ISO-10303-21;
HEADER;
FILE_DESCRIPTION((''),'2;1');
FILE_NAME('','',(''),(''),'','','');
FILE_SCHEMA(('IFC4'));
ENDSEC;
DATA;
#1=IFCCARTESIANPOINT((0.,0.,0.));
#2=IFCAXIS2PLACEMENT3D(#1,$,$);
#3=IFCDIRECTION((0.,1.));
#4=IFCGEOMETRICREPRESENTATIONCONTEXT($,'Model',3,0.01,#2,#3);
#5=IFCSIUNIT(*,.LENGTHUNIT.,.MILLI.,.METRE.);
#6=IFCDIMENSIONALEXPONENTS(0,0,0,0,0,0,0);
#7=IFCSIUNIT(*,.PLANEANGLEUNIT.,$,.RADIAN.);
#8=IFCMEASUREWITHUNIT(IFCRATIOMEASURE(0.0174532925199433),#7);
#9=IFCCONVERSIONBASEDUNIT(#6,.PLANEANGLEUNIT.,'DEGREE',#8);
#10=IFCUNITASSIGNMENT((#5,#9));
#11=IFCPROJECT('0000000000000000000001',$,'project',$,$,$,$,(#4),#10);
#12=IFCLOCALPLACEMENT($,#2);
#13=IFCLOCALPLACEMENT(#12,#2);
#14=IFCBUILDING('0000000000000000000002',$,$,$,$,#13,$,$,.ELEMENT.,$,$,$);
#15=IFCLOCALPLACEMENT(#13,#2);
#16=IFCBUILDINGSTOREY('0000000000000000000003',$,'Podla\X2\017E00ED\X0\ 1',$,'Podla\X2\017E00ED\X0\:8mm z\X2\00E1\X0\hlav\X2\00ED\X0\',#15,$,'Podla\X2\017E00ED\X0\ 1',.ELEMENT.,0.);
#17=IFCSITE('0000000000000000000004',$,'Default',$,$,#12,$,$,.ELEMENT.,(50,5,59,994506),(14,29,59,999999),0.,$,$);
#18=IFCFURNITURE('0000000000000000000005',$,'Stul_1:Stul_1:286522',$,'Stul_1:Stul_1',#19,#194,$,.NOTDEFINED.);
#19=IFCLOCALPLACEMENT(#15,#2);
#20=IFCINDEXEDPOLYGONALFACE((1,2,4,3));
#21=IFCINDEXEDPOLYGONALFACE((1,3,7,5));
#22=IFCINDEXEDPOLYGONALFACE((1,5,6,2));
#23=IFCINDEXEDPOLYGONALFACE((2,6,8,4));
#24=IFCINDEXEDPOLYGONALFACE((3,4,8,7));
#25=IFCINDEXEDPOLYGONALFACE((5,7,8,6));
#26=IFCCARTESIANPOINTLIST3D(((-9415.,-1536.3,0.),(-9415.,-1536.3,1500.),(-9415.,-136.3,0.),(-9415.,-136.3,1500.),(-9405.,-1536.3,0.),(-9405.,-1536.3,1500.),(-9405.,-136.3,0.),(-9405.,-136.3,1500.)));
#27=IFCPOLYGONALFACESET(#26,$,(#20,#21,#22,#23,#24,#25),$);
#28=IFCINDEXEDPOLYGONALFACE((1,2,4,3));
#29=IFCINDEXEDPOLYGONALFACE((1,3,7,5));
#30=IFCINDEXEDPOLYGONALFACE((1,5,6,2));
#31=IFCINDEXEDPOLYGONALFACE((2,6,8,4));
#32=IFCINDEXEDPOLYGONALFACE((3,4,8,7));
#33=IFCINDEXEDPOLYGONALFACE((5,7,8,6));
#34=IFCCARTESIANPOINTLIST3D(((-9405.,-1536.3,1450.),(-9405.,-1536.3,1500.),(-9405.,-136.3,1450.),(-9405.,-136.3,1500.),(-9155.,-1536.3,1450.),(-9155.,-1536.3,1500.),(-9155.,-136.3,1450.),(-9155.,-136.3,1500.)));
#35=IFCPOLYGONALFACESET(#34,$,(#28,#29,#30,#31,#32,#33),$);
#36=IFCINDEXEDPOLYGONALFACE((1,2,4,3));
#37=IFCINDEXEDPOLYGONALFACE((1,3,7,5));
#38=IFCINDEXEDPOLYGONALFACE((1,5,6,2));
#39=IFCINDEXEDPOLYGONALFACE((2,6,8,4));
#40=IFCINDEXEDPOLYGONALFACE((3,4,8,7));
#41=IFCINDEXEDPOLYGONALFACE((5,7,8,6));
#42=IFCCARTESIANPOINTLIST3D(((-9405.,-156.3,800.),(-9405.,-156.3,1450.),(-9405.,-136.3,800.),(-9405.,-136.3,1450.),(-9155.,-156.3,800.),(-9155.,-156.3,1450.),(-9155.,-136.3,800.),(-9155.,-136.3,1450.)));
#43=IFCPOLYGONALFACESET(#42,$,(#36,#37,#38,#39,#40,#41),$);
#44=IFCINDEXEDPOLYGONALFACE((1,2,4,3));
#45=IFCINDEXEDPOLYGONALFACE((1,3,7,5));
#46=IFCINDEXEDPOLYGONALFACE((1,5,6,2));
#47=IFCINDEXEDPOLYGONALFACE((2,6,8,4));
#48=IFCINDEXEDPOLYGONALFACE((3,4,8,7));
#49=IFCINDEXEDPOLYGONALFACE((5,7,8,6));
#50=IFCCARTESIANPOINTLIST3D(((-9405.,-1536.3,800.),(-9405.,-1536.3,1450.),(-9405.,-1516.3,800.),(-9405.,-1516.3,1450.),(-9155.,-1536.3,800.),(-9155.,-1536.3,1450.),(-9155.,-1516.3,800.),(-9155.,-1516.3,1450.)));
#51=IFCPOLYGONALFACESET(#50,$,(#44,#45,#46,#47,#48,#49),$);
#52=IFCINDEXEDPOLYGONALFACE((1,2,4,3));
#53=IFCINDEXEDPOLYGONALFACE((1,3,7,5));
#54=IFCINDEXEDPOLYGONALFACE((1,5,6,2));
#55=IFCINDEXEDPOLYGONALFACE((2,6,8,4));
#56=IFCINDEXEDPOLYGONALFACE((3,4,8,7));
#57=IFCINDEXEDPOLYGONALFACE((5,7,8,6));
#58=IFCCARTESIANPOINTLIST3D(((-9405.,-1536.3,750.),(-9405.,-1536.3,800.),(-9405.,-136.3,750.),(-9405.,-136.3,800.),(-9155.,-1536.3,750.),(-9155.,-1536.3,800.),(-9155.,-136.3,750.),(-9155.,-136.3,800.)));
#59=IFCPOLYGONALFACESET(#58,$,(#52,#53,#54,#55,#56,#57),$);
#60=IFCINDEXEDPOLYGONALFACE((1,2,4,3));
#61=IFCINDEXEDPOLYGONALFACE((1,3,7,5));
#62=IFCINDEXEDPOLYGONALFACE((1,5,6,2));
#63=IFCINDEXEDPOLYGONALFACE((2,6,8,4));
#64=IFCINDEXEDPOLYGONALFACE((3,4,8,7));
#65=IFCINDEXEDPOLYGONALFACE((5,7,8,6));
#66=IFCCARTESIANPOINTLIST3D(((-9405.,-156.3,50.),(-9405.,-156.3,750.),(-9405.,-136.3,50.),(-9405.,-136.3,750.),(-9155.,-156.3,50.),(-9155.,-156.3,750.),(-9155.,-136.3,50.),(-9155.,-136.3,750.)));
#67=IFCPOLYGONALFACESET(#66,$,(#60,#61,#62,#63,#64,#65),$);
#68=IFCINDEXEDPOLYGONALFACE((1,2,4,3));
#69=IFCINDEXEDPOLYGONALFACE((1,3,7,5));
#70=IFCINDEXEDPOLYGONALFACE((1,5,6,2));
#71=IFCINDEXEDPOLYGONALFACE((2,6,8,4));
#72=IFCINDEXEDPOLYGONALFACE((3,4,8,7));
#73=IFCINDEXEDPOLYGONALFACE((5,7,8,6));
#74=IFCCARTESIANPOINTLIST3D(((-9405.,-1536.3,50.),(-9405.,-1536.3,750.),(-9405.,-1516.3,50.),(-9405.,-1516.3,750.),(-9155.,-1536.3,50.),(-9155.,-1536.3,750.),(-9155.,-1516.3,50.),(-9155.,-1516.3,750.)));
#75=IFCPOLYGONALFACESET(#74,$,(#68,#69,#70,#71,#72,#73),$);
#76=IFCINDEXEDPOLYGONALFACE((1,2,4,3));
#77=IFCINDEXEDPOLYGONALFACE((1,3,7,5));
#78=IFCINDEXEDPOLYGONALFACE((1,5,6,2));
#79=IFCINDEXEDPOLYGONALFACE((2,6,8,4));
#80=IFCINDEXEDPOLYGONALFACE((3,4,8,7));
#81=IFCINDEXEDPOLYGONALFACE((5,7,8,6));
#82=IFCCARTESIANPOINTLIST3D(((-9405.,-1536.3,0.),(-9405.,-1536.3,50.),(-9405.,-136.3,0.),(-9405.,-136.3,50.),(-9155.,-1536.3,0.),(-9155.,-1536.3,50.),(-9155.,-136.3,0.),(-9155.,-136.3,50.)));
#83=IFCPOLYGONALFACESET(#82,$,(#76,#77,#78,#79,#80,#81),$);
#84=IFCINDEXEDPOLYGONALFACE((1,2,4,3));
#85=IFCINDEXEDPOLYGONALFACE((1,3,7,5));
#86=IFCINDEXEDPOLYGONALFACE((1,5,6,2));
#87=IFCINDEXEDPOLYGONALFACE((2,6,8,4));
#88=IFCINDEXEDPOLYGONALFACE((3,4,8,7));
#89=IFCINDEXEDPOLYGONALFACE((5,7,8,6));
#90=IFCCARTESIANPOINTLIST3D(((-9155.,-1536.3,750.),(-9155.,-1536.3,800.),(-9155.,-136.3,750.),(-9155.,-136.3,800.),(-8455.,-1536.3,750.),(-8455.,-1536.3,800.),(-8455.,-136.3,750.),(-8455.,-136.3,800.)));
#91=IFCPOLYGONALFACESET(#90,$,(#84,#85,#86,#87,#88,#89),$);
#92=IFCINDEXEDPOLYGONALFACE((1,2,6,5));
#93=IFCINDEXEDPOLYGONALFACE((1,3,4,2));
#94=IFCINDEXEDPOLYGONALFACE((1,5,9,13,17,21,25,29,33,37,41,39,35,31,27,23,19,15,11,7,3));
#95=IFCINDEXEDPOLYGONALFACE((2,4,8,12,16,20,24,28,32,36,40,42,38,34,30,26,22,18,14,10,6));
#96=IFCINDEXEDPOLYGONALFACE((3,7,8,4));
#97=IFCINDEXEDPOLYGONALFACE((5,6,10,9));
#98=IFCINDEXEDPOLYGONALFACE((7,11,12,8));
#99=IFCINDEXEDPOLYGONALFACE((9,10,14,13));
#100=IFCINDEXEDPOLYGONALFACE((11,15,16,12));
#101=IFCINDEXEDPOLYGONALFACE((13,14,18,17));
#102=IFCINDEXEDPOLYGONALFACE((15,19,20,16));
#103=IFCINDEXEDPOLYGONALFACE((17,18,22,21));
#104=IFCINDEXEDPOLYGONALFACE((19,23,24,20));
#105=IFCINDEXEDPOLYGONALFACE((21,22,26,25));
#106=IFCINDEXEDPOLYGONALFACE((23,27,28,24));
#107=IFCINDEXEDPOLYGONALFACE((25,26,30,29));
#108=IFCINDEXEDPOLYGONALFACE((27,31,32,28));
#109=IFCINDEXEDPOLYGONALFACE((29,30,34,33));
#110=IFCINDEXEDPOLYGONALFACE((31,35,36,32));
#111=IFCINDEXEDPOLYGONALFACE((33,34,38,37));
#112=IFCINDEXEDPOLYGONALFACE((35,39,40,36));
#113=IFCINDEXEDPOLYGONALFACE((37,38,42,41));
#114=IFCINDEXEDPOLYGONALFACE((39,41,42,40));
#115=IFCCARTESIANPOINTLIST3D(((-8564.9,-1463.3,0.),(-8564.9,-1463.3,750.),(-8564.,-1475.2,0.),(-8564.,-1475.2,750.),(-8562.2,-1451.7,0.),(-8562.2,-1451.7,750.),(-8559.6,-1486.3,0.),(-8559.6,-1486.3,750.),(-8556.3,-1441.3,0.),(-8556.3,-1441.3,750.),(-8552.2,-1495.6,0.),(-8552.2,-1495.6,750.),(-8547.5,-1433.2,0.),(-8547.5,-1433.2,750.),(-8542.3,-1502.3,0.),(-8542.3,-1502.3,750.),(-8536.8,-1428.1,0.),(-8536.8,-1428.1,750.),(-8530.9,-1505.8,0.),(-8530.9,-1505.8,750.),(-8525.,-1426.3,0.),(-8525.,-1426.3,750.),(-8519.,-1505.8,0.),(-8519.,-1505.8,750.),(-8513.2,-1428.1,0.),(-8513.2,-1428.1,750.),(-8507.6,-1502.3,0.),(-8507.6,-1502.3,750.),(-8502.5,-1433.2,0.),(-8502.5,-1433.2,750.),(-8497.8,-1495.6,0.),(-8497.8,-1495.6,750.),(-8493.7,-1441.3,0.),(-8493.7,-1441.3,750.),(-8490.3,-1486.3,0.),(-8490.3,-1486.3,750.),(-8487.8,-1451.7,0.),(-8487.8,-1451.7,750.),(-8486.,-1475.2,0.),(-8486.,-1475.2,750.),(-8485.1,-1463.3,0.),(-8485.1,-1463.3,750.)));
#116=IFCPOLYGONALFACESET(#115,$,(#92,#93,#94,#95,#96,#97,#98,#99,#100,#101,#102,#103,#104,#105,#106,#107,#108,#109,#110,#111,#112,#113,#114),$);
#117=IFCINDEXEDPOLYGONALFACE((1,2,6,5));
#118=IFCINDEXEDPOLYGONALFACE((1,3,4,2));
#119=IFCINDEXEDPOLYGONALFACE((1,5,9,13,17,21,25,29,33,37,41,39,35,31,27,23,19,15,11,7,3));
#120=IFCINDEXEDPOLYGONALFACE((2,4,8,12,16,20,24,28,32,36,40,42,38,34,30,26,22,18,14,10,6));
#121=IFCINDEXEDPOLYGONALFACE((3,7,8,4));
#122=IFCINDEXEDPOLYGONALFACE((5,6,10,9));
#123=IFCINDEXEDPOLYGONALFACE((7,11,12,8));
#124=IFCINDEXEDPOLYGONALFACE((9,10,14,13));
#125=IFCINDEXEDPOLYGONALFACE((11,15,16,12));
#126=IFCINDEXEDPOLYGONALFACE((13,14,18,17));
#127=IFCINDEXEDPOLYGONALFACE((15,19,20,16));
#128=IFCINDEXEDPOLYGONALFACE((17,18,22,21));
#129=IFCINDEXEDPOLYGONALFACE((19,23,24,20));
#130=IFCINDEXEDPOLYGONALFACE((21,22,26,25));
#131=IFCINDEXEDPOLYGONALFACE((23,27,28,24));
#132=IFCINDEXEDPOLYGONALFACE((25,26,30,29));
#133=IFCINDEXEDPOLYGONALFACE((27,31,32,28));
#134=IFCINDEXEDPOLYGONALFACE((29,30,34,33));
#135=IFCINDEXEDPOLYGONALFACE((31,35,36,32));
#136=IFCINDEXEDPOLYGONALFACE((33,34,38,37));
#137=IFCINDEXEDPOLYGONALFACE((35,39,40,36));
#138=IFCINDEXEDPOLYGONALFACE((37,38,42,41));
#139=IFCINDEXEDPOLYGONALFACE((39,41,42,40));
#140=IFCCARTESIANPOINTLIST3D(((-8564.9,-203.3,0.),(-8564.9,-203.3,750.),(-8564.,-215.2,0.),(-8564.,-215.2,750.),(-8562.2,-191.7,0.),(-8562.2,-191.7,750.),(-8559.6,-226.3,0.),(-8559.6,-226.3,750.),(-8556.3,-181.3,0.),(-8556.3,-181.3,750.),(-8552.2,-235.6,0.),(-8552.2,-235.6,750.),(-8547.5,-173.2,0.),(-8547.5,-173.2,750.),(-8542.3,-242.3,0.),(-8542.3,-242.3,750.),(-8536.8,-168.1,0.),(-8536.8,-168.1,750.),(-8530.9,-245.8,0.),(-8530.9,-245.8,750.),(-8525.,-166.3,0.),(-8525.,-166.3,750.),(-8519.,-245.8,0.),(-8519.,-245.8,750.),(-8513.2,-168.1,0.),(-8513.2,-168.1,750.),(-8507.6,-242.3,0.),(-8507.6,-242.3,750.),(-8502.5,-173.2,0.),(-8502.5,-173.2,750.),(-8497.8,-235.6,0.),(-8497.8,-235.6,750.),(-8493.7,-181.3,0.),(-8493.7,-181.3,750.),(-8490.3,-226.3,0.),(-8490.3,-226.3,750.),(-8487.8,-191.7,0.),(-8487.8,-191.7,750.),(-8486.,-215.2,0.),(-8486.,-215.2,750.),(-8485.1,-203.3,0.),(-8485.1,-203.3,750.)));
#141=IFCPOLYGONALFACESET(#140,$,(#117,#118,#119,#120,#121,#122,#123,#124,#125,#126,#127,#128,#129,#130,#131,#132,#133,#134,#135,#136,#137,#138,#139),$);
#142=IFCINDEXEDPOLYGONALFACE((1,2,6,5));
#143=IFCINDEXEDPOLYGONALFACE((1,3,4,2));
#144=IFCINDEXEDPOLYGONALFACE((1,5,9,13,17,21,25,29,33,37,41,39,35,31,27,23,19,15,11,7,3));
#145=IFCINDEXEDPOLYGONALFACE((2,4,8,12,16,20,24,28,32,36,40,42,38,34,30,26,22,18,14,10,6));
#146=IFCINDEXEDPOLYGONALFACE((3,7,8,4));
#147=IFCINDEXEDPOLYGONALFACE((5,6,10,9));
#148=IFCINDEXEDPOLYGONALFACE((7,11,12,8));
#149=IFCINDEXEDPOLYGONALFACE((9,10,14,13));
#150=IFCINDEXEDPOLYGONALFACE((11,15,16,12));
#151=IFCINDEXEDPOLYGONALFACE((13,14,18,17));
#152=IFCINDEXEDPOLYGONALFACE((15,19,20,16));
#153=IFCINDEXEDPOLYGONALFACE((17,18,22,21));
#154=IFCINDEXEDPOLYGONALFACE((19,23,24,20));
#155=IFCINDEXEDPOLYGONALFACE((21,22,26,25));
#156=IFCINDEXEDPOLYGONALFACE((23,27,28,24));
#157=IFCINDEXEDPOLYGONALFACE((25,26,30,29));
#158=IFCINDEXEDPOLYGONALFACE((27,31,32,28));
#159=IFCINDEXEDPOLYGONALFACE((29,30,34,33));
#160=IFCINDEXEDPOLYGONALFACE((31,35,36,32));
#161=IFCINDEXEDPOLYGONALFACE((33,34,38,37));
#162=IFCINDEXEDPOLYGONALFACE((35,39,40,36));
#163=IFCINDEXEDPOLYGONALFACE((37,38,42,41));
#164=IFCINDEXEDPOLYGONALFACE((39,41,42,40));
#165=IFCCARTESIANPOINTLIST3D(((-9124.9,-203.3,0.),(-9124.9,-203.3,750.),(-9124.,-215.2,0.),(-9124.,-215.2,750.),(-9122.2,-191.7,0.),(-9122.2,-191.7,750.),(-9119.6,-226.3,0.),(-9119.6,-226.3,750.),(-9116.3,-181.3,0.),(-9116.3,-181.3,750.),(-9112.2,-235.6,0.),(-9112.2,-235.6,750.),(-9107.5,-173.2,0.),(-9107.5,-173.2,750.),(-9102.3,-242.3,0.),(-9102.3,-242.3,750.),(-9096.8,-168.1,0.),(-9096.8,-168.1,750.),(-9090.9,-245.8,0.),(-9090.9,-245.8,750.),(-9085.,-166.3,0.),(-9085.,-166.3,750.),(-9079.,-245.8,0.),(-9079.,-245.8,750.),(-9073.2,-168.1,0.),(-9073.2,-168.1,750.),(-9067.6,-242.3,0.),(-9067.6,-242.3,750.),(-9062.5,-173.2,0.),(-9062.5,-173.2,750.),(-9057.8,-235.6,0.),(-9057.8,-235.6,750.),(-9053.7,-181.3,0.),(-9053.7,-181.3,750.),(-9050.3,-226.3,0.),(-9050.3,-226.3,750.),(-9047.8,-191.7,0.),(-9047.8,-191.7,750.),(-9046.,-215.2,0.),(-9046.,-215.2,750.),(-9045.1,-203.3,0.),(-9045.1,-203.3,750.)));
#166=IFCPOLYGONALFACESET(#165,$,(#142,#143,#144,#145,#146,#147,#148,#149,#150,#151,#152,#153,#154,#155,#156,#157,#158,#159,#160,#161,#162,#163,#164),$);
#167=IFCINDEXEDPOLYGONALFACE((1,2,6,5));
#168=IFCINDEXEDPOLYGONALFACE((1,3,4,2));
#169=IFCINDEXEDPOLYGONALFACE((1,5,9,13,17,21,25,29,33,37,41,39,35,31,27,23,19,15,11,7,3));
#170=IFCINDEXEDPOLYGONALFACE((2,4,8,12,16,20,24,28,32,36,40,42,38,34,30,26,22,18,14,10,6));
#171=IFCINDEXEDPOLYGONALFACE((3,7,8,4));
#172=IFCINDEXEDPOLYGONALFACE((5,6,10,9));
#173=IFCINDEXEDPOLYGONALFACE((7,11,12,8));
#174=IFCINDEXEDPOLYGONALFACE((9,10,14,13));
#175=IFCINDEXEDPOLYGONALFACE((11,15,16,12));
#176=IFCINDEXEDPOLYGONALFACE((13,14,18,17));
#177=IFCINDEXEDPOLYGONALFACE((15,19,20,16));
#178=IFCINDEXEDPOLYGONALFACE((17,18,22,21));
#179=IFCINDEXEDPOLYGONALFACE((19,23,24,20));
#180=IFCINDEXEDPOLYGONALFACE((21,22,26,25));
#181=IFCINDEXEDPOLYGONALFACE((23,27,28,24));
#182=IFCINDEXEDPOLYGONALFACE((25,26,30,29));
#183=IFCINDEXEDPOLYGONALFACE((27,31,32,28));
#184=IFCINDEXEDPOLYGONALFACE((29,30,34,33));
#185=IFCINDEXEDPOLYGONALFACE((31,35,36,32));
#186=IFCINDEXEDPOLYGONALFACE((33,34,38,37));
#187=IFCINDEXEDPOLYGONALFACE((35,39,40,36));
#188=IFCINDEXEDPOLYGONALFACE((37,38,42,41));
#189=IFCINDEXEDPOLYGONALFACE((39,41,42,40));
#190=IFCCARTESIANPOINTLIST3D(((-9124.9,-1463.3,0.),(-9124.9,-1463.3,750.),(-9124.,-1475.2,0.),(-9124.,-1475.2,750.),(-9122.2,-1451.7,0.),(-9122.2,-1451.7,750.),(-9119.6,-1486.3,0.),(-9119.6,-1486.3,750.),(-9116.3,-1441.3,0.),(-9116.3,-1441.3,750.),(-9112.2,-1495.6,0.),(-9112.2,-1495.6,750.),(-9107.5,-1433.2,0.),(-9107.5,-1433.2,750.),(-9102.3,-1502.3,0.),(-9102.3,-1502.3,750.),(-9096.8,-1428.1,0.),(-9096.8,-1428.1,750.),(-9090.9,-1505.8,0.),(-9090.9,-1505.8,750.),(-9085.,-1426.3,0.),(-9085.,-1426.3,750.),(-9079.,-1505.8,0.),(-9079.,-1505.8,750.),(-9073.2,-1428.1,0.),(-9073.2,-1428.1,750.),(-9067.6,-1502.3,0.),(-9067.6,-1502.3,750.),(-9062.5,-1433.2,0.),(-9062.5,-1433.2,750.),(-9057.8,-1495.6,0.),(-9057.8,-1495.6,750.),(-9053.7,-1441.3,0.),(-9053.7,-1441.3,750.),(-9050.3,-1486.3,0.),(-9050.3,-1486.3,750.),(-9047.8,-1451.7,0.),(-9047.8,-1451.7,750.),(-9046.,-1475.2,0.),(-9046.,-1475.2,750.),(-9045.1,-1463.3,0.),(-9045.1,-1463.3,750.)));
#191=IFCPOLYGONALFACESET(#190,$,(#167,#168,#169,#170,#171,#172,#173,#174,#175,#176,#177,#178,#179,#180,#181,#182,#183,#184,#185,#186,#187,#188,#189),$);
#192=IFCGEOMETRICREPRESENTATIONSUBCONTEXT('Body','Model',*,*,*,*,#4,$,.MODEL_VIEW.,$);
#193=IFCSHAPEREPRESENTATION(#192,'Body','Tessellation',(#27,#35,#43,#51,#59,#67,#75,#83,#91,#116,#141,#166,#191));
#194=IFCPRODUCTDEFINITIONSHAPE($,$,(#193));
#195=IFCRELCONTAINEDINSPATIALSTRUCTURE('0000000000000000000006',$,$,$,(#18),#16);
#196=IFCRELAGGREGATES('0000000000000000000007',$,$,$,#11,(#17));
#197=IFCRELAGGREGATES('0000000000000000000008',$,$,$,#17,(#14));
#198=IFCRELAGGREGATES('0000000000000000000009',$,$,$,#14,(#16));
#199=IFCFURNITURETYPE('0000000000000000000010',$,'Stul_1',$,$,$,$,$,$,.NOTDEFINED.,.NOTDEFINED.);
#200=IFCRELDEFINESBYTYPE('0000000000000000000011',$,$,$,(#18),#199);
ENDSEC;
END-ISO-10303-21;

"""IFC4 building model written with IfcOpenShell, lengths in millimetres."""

from ifc_helpers import new_model, entity, si_unit, converted_unit, direction, frame, frame_2d, origin, origin_2d_with_axis, place, context, subcontext, project, spatial, rectangle, circle, extrude, source, transform, mapped, type_object, type_shapes, element, save


model = new_model("IFC4")

# Units and contexts
model_context = context("Model", 3, precision=0.01, world=origin(), true_north=direction((0.0, 1.0)))
body_context = subcontext(model_context, "Body", "Model", "MODEL_VIEW")
ifc_project = project(units=[si_unit("LENGTHUNIT", "METRE", prefix="MILLI"), converted_unit("PLANEANGLEUNIT", "DEGREE", entity("IfcRatioMeasure", 0.0174532925199433), si_unit("PLANEANGLEUNIT", "RADIAN"), dimensions=[0, 0, 0, 0, 0, 0, 0])], contexts=[model_context])

# Site, building, storey
site_placement = place(None, origin())
site = spatial("IfcSite", under=ifc_project, at=site_placement, Name="Default", CompositionType="ELEMENT", RefLatitude=(50, 5, 59, 994506), RefLongitude=(14, 29, 59, 999999), RefElevation=0.0)
building_placement = place(site_placement, origin())
building = spatial("IfcBuilding", under=site, at=building_placement, CompositionType="ELEMENT")
storey_placement = place(building_placement, origin())
storey = spatial("IfcBuildingStorey", under=building, at=storey_placement, Name="Podlaží 1", ObjectType="Podlaží:8mm záhlaví", LongName="Podlaží 1", CompositionType="ELEMENT", Elevation=0.0)

# Furniture
furniture_type = type_object("IfcFurnitureType", Name="Stul_1", AssemblyPlace="NOTDEFINED", PredefinedType="NOTDEFINED")
shared_shape_1 = source(origin(), body_context, "Body", "SweptSolid", [
    extrude(rectangle(XDim=1400.0, YDim=10.0, at=origin_2d_with_axis()), frame((0.0, 605.0, 0.0), z_axis=(0.0, 0.0, 1.0), x_axis=(-1.0, 0.0, 0.0)), (0.0, 0.0, 1.0), 1500.0),
    extrude(rectangle(XDim=1400.0, YDim=250.0, at=frame_2d((0.0, 0.0), x_axis=(1.0, 0.0))), frame((0.0, 475.0, 1450.0), z_axis=(0.0, 0.0, 1.0), x_axis=(-1.0, 0.0, 0.0)), (0.0, 0.0, 1.0), 50.0),
    extrude(rectangle(XDim=20.0, YDim=250.0, at=origin_2d_with_axis()), frame((690.0, 475.0, 800.0), z_axis=(0.0, 0.0, 1.0), x_axis=(-1.0, 0.0, 0.0)), (0.0, 0.0, 1.0), 650.0),
    extrude(rectangle(XDim=20.0, YDim=250.0, at=frame_2d((0.0, 0.0), x_axis=(1.0, 0.0))), frame((-690.0, 475.0, 800.0), z_axis=(0.0, 0.0, 1.0), x_axis=(-1.0, 0.0, 0.0)), (0.0, 0.0, 1.0), 650.0),
    extrude(rectangle(XDim=1400.0, YDim=250.0, at=origin_2d_with_axis()), frame((0.0, 475.0, 750.0), z_axis=(0.0, 0.0, 1.0), x_axis=(-1.0, 0.0, 0.0)), (0.0, 0.0, 1.0), 50.0),
    extrude(rectangle(XDim=20.0, YDim=250.0, at=origin_2d_with_axis()), frame((690.0, 475.0, 50.0), z_axis=(0.0, 0.0, 1.0), x_axis=(-1.0, 0.0, 0.0)), (0.0, 0.0, 1.0), 700.0),
    extrude(rectangle(XDim=20.0, YDim=250.0, at=frame_2d((0.0, 0.0), x_axis=(1.0, 0.0))), frame((-690.0, 475.0, 50.0), z_axis=(0.0, 0.0, 1.0), x_axis=(-1.0, 0.0, 0.0)), (0.0, 0.0, 1.0), 700.0),
    extrude(rectangle(XDim=1400.0, YDim=250.0, at=origin_2d_with_axis()), frame((0.0, 475.0, 0.0), z_axis=(0.0, 0.0, 1.0), x_axis=(-1.0, 0.0, 0.0)), (0.0, 0.0, 1.0), 50.0),
    extrude(rectangle(XDim=1400.0, YDim=700.0, at=origin_2d_with_axis()), frame((0.0, 0.0, 750.0), z_axis=(0.0, 0.0, 1.0), x_axis=(-1.0, 0.0, 0.0)), (0.0, 0.0, 1.0), 50.0),
    extrude(circle(Radius=40.0, at=frame_2d((0.0, 0.0), x_axis=(1.0, 0.0))), frame((-630.0, -280.0, 0.0)), (0.0, 0.0, 1.0), 750.0),
    extrude(circle(Radius=40.0, at=frame_2d((0.0, 0.0), x_axis=(1.0, 0.0))), frame((630.0, -280.0, 0.0)), (0.0, 0.0, 1.0), 750.0),
    extrude(circle(Radius=40.0, at=frame_2d((0.0, 0.0), x_axis=(1.0, 0.0))), frame((630.0, 280.0, 0.0)), (0.0, 0.0, 1.0), 750.0),
    extrude(circle(Radius=40.0, at=frame_2d((0.0, 0.0), x_axis=(1.0, 0.0))), frame((-630.0, 280.0, 0.0)), (0.0, 0.0, 1.0), 750.0),
])
type_shapes(furniture_type, [shared_shape_1])
for number, where, z_axis, x_axis, name in (
    (1, (-8805.0, -836.3, 0.0), (0.0, 0.0, 1.0), (0.0, 1.0, 0.0), "Stul_1:Stul_1:286522"),
):
    element("IfcFurniture", number, at=place(storey_placement, frame(where, z_axis=z_axis, x_axis=x_axis)), inside=storey, type_object=furniture_type, Name=name, ObjectType="Stul_1:Stul_1", PredefinedType="NOTDEFINED", context=body_context, shape_type="MappedRepresentation", body=[
        mapped(shared_shape_1, transform((0.0, 0.0, 0.0), scale=1.0)),
    ])

save(model, "model.ifc")
